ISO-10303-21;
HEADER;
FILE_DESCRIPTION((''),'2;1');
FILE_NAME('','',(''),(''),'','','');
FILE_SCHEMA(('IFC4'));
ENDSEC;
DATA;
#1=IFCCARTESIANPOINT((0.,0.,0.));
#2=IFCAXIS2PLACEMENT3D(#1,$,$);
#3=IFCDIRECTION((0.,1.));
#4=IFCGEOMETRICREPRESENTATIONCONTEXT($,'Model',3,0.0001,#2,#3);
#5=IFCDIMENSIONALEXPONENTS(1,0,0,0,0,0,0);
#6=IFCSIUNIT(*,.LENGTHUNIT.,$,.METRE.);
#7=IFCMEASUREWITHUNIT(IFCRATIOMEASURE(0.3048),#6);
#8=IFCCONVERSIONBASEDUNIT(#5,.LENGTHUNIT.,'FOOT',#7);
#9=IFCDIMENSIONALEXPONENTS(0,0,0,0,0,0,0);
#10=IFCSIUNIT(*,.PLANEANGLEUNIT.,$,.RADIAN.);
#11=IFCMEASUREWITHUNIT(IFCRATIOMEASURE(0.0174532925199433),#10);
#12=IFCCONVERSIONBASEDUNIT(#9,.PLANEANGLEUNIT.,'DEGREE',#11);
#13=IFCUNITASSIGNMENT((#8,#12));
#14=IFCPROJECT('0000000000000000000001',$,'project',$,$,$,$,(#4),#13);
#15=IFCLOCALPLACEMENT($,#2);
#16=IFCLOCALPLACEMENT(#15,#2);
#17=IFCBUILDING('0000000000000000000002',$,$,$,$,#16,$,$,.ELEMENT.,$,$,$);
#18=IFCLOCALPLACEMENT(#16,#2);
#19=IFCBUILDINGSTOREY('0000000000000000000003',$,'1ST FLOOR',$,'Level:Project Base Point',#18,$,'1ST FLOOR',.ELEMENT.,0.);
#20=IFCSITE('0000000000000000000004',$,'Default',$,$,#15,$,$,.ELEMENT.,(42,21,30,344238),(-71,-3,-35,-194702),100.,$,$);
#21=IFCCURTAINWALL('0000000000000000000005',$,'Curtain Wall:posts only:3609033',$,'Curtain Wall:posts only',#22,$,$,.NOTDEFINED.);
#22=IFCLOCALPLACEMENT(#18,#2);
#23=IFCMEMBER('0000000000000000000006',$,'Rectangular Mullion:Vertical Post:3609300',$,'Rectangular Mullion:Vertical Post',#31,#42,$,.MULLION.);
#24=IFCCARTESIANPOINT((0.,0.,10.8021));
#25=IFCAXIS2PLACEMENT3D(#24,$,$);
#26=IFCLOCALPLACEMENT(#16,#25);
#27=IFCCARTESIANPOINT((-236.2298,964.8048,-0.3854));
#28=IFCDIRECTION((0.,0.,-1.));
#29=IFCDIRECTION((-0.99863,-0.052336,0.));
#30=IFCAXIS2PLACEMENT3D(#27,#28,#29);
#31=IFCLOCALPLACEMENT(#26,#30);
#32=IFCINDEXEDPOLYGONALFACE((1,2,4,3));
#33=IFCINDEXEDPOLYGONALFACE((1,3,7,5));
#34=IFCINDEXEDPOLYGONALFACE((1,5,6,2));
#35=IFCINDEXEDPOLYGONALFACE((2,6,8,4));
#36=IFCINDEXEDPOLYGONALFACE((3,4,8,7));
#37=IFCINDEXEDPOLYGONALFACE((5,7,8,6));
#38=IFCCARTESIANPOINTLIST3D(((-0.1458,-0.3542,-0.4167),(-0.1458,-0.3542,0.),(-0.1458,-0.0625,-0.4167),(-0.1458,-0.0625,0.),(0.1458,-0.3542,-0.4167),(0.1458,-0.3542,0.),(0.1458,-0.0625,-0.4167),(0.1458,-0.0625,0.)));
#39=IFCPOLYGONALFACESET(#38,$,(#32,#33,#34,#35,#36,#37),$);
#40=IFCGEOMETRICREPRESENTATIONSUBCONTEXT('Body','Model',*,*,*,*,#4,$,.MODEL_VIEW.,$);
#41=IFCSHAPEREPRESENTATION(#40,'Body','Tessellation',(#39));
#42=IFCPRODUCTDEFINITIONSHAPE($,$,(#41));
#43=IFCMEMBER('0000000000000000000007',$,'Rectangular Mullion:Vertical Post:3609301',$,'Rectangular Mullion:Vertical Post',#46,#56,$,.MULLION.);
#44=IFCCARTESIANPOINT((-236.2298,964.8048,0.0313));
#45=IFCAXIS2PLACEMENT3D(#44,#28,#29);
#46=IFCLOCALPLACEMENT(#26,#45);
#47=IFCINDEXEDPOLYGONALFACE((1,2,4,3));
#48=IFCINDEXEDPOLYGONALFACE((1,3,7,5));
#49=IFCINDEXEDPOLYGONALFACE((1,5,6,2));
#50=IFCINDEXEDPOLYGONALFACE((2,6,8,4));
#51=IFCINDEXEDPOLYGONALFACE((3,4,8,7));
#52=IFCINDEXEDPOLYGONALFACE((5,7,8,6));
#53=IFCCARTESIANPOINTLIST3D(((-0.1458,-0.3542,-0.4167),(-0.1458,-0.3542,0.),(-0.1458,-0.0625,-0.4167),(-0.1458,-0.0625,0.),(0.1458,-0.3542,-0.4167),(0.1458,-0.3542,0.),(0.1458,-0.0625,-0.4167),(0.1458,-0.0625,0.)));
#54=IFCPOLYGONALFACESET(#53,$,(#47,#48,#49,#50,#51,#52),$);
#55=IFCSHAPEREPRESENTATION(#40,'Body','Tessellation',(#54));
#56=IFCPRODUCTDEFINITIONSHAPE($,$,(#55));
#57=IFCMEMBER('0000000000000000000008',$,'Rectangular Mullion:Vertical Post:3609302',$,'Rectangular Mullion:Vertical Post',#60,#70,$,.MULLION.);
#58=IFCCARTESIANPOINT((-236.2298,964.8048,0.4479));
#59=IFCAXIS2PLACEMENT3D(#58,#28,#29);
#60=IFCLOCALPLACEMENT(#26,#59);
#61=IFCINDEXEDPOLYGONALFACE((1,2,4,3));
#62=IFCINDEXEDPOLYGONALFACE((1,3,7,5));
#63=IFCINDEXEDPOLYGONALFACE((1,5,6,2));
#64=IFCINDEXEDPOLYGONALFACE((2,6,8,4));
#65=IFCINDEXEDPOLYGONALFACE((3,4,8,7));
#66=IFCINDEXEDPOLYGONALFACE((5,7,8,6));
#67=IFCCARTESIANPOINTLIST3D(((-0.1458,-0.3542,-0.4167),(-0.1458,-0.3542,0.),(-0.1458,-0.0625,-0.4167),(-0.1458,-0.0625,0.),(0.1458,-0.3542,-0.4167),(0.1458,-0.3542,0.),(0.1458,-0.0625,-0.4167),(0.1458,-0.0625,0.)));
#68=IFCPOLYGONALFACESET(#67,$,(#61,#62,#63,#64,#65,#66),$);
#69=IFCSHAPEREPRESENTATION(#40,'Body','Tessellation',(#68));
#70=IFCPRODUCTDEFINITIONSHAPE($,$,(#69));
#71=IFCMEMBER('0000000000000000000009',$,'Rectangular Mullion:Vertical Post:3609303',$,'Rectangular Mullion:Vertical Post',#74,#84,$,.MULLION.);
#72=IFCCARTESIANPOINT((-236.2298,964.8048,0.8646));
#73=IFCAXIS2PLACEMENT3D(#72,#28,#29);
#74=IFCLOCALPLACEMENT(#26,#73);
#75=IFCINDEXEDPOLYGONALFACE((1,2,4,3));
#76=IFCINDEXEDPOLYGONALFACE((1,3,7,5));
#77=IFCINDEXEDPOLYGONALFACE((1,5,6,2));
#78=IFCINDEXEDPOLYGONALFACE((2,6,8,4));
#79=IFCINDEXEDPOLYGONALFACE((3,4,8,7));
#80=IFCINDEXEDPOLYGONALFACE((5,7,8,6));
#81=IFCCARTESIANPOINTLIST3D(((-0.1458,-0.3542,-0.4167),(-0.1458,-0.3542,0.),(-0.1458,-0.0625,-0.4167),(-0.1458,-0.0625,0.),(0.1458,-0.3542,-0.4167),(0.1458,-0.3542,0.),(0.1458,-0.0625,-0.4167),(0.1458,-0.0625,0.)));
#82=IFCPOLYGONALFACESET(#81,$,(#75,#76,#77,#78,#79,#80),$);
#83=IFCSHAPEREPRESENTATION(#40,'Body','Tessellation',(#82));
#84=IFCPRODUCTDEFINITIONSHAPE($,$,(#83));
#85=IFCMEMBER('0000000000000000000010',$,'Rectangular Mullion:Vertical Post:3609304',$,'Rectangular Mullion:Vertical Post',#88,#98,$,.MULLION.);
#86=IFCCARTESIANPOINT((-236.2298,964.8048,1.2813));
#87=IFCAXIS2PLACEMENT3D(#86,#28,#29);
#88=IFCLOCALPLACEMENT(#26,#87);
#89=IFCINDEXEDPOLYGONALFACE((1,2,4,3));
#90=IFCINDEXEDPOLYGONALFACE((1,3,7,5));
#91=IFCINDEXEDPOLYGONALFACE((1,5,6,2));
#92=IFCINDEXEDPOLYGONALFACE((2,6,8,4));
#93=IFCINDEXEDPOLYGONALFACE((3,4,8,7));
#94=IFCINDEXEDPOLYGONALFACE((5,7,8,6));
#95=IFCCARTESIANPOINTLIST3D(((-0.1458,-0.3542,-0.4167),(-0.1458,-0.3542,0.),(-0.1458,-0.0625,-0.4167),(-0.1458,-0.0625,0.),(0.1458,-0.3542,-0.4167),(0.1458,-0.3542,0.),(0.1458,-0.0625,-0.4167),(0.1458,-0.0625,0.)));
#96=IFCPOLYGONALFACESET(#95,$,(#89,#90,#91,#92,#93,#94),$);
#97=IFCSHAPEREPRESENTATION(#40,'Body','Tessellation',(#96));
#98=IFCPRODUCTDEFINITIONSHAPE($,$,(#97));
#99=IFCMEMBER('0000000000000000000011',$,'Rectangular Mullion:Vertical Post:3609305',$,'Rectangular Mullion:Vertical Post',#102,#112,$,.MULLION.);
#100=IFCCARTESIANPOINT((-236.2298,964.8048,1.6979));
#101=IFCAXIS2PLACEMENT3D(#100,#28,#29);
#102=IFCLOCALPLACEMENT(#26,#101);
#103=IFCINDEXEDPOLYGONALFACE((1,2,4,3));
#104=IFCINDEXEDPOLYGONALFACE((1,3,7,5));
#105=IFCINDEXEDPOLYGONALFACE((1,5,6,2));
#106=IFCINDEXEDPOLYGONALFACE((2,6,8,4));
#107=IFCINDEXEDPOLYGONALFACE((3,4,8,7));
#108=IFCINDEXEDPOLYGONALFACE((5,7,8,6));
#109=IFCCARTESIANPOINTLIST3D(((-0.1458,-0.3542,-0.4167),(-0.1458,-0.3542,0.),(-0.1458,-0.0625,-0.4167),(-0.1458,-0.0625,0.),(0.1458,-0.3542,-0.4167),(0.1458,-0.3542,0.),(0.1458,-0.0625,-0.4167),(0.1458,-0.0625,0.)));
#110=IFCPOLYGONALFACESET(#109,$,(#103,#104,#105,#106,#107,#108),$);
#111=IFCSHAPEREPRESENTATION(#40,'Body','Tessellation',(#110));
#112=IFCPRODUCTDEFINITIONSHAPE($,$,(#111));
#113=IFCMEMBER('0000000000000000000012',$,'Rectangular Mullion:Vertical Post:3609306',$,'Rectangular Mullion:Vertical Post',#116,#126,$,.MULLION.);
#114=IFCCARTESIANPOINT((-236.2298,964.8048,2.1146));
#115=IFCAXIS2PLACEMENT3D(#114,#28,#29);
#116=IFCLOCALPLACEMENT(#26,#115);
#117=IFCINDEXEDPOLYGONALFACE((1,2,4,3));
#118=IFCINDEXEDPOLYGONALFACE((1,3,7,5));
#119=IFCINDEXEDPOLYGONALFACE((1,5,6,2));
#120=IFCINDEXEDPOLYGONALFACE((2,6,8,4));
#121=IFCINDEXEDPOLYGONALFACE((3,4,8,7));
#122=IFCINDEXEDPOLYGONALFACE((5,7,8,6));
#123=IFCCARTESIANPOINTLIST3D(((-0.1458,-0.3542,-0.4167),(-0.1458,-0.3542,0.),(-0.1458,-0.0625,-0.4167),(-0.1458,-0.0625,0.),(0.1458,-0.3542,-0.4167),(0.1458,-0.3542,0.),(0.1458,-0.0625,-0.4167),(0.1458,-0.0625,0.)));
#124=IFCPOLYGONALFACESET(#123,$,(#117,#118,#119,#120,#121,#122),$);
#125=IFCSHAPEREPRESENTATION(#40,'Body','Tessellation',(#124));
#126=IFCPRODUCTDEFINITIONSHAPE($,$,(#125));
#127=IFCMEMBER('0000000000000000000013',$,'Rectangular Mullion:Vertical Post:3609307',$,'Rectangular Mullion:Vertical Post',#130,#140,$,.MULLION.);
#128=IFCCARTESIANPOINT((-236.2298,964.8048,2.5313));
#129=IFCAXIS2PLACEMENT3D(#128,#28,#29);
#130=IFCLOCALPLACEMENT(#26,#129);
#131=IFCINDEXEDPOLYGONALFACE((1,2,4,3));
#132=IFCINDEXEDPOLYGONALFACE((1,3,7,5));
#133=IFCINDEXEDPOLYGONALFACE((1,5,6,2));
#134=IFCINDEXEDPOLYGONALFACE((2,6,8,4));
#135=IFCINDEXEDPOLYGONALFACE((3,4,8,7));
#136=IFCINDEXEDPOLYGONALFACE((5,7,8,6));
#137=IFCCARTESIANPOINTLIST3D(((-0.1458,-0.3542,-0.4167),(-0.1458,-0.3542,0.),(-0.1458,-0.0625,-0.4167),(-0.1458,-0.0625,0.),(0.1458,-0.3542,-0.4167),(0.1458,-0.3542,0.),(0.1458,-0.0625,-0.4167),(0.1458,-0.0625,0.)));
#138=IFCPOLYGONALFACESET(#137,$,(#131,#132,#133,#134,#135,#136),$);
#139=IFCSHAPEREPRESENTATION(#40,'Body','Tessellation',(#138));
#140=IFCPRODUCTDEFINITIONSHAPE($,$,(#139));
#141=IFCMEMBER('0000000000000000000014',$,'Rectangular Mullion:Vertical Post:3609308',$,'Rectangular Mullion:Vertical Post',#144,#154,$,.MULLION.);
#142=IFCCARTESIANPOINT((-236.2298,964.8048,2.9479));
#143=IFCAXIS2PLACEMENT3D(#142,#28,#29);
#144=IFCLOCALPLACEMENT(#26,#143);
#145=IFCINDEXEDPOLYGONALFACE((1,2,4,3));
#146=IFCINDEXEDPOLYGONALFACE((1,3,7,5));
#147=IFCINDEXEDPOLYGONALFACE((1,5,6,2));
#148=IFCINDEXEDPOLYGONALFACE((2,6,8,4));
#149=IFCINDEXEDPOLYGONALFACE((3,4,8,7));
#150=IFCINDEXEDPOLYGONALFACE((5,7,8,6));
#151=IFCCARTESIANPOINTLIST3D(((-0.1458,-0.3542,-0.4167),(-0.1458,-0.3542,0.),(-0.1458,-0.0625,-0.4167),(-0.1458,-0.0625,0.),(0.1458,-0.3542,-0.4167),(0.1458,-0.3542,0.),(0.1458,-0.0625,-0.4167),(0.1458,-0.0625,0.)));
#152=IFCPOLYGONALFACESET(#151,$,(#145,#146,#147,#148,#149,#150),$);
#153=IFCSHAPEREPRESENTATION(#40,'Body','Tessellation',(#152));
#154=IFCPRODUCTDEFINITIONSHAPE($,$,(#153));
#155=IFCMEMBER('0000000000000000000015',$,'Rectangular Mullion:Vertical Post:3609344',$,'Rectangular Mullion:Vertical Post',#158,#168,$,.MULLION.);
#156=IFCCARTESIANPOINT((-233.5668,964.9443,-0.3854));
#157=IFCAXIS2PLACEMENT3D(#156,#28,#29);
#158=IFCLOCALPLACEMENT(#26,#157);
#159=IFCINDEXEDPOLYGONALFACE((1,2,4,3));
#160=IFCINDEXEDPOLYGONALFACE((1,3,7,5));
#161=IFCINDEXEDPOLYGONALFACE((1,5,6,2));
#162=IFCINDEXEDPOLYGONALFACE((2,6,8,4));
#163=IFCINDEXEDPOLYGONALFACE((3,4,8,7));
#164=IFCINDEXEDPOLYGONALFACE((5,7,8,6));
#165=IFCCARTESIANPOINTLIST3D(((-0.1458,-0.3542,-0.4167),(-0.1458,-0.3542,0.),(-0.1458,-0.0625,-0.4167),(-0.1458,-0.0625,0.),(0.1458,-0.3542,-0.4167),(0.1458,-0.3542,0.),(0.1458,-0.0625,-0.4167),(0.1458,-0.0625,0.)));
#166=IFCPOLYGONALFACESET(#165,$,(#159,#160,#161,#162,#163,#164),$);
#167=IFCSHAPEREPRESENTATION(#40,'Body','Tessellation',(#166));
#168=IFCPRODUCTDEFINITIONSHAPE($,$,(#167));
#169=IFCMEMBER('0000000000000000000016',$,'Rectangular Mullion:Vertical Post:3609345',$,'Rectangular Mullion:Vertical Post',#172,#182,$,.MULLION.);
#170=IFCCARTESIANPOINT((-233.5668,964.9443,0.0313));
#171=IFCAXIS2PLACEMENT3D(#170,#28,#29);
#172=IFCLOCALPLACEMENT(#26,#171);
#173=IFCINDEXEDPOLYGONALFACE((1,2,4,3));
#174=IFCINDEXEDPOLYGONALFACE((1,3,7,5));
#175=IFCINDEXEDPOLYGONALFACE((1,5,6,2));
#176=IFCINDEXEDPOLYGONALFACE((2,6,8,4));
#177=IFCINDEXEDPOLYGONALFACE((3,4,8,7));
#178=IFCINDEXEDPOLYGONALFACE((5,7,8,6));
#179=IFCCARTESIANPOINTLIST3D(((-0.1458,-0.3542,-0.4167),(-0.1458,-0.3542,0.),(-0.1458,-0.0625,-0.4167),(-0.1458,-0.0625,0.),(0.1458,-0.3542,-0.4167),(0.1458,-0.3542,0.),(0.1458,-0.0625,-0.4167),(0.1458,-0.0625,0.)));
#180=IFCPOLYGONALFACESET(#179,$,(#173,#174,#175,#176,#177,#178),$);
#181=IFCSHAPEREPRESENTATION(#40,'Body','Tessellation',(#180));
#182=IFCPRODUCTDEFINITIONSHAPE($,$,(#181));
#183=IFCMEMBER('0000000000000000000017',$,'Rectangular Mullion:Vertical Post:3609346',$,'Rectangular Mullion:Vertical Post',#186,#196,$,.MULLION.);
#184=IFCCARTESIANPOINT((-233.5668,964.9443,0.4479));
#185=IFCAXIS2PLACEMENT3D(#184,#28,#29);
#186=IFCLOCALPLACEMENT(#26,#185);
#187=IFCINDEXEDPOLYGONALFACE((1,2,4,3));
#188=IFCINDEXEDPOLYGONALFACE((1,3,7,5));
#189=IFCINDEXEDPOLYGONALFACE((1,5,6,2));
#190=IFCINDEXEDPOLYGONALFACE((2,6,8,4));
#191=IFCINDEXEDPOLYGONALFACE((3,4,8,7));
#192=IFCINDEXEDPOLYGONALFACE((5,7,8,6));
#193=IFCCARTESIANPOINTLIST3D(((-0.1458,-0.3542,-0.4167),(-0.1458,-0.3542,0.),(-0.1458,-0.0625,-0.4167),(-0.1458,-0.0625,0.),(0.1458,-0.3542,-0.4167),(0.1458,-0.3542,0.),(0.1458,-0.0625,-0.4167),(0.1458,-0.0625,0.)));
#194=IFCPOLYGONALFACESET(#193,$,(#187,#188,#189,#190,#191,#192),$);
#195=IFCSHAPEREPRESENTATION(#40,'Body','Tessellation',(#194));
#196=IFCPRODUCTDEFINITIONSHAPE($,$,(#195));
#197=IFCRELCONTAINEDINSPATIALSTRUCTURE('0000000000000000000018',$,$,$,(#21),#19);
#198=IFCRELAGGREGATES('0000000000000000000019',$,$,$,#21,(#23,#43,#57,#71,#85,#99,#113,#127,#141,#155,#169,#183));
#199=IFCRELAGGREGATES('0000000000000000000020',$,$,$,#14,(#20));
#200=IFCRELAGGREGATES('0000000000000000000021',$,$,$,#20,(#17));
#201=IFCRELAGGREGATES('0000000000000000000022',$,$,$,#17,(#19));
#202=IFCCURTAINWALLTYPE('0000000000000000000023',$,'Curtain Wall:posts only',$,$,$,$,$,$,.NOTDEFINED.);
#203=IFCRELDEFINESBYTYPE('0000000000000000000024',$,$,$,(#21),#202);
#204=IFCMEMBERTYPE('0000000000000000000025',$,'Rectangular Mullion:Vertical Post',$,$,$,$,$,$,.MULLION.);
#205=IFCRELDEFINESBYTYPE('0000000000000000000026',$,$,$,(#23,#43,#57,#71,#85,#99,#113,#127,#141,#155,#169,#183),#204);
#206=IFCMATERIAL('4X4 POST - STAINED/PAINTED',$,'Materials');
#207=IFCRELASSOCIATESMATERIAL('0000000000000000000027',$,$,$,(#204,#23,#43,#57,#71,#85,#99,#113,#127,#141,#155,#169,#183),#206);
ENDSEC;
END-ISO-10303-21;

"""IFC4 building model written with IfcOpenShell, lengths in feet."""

from ifc_helpers import new_model, entity, si_unit, converted_unit, direction, frame, origin, origin_2d_with_axis, place, context, subcontext, project, spatial, rectangle, extrude, source, transform, mapped, material, material_profile, profile_set, profile_usage, type_object, type_shapes, element, aggregate, save


model = new_model("IFC4")

# Units and contexts
model_context = context("Model", 3, precision=0.0001, world=origin(), true_north=direction((0.0, 1.0)))
body_context = subcontext(model_context, "Body", "Model", "MODEL_VIEW")
ifc_project = project(units=[converted_unit("LENGTHUNIT", "FOOT", entity("IfcRatioMeasure", 0.3048), si_unit("LENGTHUNIT", "METRE"), dimensions=[1, 0, 0, 0, 0, 0, 0]), converted_unit("PLANEANGLEUNIT", "DEGREE", entity("IfcRatioMeasure", 0.0174532925199433), si_unit("PLANEANGLEUNIT", "RADIAN"), dimensions=[0, 0, 0, 0, 0, 0, 0])], contexts=[model_context])

# Site, building, storey
site_placement = place(None, origin())
site = spatial("IfcSite", under=ifc_project, at=site_placement, Name="Default", CompositionType="ELEMENT", RefLatitude=(42, 21, 30, 344238), RefLongitude=(-71, -3, -35, -194702), RefElevation=100.0)
building_placement = place(site_placement, origin())
building = spatial("IfcBuilding", under=site, at=building_placement, CompositionType="ELEMENT")
storey_placement = place(building_placement, origin())
storey = spatial("IfcBuildingStorey", under=building, at=storey_placement, Name="1ST FLOOR", ObjectType="Level:Project Base Point", LongName="1ST FLOOR", CompositionType="ELEMENT", Elevation=0.0)

# Curtain wall, members
curtain_wall_type_1 = type_object("IfcCurtainWallType", Name="Curtain Wall:posts only", PredefinedType="NOTDEFINED")
curtain_wall_1_placement = place(storey_placement, origin())
curtain_wall_1 = element("IfcCurtainWall", 1, at=curtain_wall_1_placement, inside=storey, type_object=curtain_wall_type_1, Name="Curtain Wall:posts only:3609033", ObjectType="Curtain Wall:posts only", PredefinedType="NOTDEFINED")
ifc_material_1 = material(Name="4X4 POST - STAINED/PAINTED", Category="Materials")
ifc_material_profile_1 = material_profile(ifc_material_1, rectangle(XDim=0.2917, YDim=0.2917, at=origin_2d_with_axis()), Name="Vertical Post")
ifc_profile_set_1 = profile_set([ifc_material_profile_1], Name="Vertical Post")
ifc_profile_usage_1 = profile_usage(ifc_profile_set_1)
member_type_1 = type_object("IfcMemberType", Name="Rectangular Mullion:Vertical Post", PredefinedType="MULLION", material=ifc_profile_set_1)
shared_shape_1 = source(origin(), body_context, "Body", "SweptSolid", [
    extrude(rectangle(XDim=0.2917, YDim=0.2917, at=origin_2d_with_axis()), frame((0.0, -0.2083, -0.4167), z_axis=(0.0, 0.0, 1.0), x_axis=(0.0, -1.0, 0.0)), (0.0, 0.0, 1.0), 0.4167),
])
type_shapes(member_type_1, [shared_shape_1])
placement = place(building_placement, frame((0.0, 0.0, 10.8021)))
member_1_placement = place(placement, frame((-236.2298, 964.8048, -0.3854), z_axis=(0.0, 0.0, -1.0), x_axis=(-0.99863, -0.052336, 0.0)))
member_1 = element("IfcMember", 2, at=member_1_placement, type_object=member_type_1, material=ifc_profile_usage_1, Name="Rectangular Mullion:Vertical Post:3609300", ObjectType="Rectangular Mullion:Vertical Post", PredefinedType="MULLION", context=body_context, shape_type="MappedRepresentation", body=[
    mapped(shared_shape_1, transform((0.0, 0.0, 0.0), scale=1.0)),
])
ifc_profile_usage_2 = profile_usage(ifc_profile_set_1)
member_2_placement = place(placement, frame((-236.2298, 964.8048, 0.0313), z_axis=(0.0, 0.0, -1.0), x_axis=(-0.99863, -0.052336, 0.0)))
member_2 = element("IfcMember", 3, at=member_2_placement, type_object=member_type_1, material=ifc_profile_usage_2, Name="Rectangular Mullion:Vertical Post:3609301", ObjectType="Rectangular Mullion:Vertical Post", PredefinedType="MULLION", context=body_context, shape_type="MappedRepresentation", body=[
    mapped(shared_shape_1, transform((0.0, 0.0, 0.0), scale=1.0)),
])
ifc_profile_usage_3 = profile_usage(ifc_profile_set_1)
member_3_placement = place(placement, frame((-236.2298, 964.8048, 0.4479), z_axis=(0.0, 0.0, -1.0), x_axis=(-0.99863, -0.052336, 0.0)))
member_3 = element("IfcMember", 4, at=member_3_placement, type_object=member_type_1, material=ifc_profile_usage_3, Name="Rectangular Mullion:Vertical Post:3609302", ObjectType="Rectangular Mullion:Vertical Post", PredefinedType="MULLION", context=body_context, shape_type="MappedRepresentation", body=[
    mapped(shared_shape_1, transform((0.0, 0.0, 0.0), scale=1.0)),
])
ifc_profile_usage_4 = profile_usage(ifc_profile_set_1)
member_4_placement = place(placement, frame((-236.2298, 964.8048, 0.8646), z_axis=(0.0, 0.0, -1.0), x_axis=(-0.99863, -0.052336, 0.0)))
member_4 = element("IfcMember", 5, at=member_4_placement, type_object=member_type_1, material=ifc_profile_usage_4, Name="Rectangular Mullion:Vertical Post:3609303", ObjectType="Rectangular Mullion:Vertical Post", PredefinedType="MULLION", context=body_context, shape_type="MappedRepresentation", body=[
    mapped(shared_shape_1, transform((0.0, 0.0, 0.0), scale=1.0)),
])
ifc_profile_usage_5 = profile_usage(ifc_profile_set_1)
member_5_placement = place(placement, frame((-236.2298, 964.8048, 1.2813), z_axis=(0.0, 0.0, -1.0), x_axis=(-0.99863, -0.052336, 0.0)))
member_5 = element("IfcMember", 6, at=member_5_placement, type_object=member_type_1, material=ifc_profile_usage_5, Name="Rectangular Mullion:Vertical Post:3609304", ObjectType="Rectangular Mullion:Vertical Post", PredefinedType="MULLION", context=body_context, shape_type="MappedRepresentation", body=[
    mapped(shared_shape_1, transform((0.0, 0.0, 0.0), scale=1.0)),
])
ifc_profile_usage_6 = profile_usage(ifc_profile_set_1)
member_6_placement = place(placement, frame((-236.2298, 964.8048, 1.6979), z_axis=(0.0, 0.0, -1.0), x_axis=(-0.99863, -0.052336, 0.0)))
member_6 = element("IfcMember", 7, at=member_6_placement, type_object=member_type_1, material=ifc_profile_usage_6, Name="Rectangular Mullion:Vertical Post:3609305", ObjectType="Rectangular Mullion:Vertical Post", PredefinedType="MULLION", context=body_context, shape_type="MappedRepresentation", body=[
    mapped(shared_shape_1, transform((0.0, 0.0, 0.0), scale=1.0)),
])
ifc_profile_usage_7 = profile_usage(ifc_profile_set_1)
member_7_placement = place(placement, frame((-236.2298, 964.8048, 2.1146), z_axis=(0.0, 0.0, -1.0), x_axis=(-0.99863, -0.052336, 0.0)))
member_7 = element("IfcMember", 8, at=member_7_placement, type_object=member_type_1, material=ifc_profile_usage_7, Name="Rectangular Mullion:Vertical Post:3609306", ObjectType="Rectangular Mullion:Vertical Post", PredefinedType="MULLION", context=body_context, shape_type="MappedRepresentation", body=[
    mapped(shared_shape_1, transform((0.0, 0.0, 0.0), scale=1.0)),
])
ifc_profile_usage_8 = profile_usage(ifc_profile_set_1)
member_8_placement = place(placement, frame((-236.2298, 964.8048, 2.5313), z_axis=(0.0, 0.0, -1.0), x_axis=(-0.99863, -0.052336, 0.0)))
member_8 = element("IfcMember", 9, at=member_8_placement, type_object=member_type_1, material=ifc_profile_usage_8, Name="Rectangular Mullion:Vertical Post:3609307", ObjectType="Rectangular Mullion:Vertical Post", PredefinedType="MULLION", context=body_context, shape_type="MappedRepresentation", body=[
    mapped(shared_shape_1, transform((0.0, 0.0, 0.0), scale=1.0)),
])
ifc_profile_usage_9 = profile_usage(ifc_profile_set_1)
member_9_placement = place(placement, frame((-236.2298, 964.8048, 2.9479), z_axis=(0.0, 0.0, -1.0), x_axis=(-0.99863, -0.052336, 0.0)))
member_9 = element("IfcMember", 10, at=member_9_placement, type_object=member_type_1, material=ifc_profile_usage_9, Name="Rectangular Mullion:Vertical Post:3609308", ObjectType="Rectangular Mullion:Vertical Post", PredefinedType="MULLION", context=body_context, shape_type="MappedRepresentation", body=[
    mapped(shared_shape_1, transform((0.0, 0.0, 0.0), scale=1.0)),
])
ifc_profile_usage_10 = profile_usage(ifc_profile_set_1)
member_10_placement = place(placement, frame((-233.5668, 964.9443, -0.3854), z_axis=(0.0, 0.0, -1.0), x_axis=(-0.99863, -0.052336, 0.0)))
member_10 = element("IfcMember", 11, at=member_10_placement, type_object=member_type_1, material=ifc_profile_usage_10, Name="Rectangular Mullion:Vertical Post:3609344", ObjectType="Rectangular Mullion:Vertical Post", PredefinedType="MULLION", context=body_context, shape_type="MappedRepresentation", body=[
    mapped(shared_shape_1, transform((0.0, 0.0, 0.0), scale=1.0)),
])
ifc_profile_usage_11 = profile_usage(ifc_profile_set_1)
member_11_placement = place(placement, frame((-233.5668, 964.9443, 0.0313), z_axis=(0.0, 0.0, -1.0), x_axis=(-0.99863, -0.052336, 0.0)))
member_11 = element("IfcMember", 12, at=member_11_placement, type_object=member_type_1, material=ifc_profile_usage_11, Name="Rectangular Mullion:Vertical Post:3609345", ObjectType="Rectangular Mullion:Vertical Post", PredefinedType="MULLION", context=body_context, shape_type="MappedRepresentation", body=[
    mapped(shared_shape_1, transform((0.0, 0.0, 0.0), scale=1.0)),
])
ifc_profile_usage_12 = profile_usage(ifc_profile_set_1)
member_12_placement = place(placement, frame((-233.5668, 964.9443, 0.4479), z_axis=(0.0, 0.0, -1.0), x_axis=(-0.99863, -0.052336, 0.0)))
member_12 = element("IfcMember", 13, at=member_12_placement, type_object=member_type_1, material=ifc_profile_usage_12, Name="Rectangular Mullion:Vertical Post:3609346", ObjectType="Rectangular Mullion:Vertical Post", PredefinedType="MULLION", context=body_context, shape_type="MappedRepresentation", body=[
    mapped(shared_shape_1, transform((0.0, 0.0, 0.0), scale=1.0)),
])
aggregate(curtain_wall_1, [member_1, member_2, member_3, member_4, member_5, member_6, member_7, member_8, member_9, member_10, member_11, member_12])

save(model, "model.ifc")
